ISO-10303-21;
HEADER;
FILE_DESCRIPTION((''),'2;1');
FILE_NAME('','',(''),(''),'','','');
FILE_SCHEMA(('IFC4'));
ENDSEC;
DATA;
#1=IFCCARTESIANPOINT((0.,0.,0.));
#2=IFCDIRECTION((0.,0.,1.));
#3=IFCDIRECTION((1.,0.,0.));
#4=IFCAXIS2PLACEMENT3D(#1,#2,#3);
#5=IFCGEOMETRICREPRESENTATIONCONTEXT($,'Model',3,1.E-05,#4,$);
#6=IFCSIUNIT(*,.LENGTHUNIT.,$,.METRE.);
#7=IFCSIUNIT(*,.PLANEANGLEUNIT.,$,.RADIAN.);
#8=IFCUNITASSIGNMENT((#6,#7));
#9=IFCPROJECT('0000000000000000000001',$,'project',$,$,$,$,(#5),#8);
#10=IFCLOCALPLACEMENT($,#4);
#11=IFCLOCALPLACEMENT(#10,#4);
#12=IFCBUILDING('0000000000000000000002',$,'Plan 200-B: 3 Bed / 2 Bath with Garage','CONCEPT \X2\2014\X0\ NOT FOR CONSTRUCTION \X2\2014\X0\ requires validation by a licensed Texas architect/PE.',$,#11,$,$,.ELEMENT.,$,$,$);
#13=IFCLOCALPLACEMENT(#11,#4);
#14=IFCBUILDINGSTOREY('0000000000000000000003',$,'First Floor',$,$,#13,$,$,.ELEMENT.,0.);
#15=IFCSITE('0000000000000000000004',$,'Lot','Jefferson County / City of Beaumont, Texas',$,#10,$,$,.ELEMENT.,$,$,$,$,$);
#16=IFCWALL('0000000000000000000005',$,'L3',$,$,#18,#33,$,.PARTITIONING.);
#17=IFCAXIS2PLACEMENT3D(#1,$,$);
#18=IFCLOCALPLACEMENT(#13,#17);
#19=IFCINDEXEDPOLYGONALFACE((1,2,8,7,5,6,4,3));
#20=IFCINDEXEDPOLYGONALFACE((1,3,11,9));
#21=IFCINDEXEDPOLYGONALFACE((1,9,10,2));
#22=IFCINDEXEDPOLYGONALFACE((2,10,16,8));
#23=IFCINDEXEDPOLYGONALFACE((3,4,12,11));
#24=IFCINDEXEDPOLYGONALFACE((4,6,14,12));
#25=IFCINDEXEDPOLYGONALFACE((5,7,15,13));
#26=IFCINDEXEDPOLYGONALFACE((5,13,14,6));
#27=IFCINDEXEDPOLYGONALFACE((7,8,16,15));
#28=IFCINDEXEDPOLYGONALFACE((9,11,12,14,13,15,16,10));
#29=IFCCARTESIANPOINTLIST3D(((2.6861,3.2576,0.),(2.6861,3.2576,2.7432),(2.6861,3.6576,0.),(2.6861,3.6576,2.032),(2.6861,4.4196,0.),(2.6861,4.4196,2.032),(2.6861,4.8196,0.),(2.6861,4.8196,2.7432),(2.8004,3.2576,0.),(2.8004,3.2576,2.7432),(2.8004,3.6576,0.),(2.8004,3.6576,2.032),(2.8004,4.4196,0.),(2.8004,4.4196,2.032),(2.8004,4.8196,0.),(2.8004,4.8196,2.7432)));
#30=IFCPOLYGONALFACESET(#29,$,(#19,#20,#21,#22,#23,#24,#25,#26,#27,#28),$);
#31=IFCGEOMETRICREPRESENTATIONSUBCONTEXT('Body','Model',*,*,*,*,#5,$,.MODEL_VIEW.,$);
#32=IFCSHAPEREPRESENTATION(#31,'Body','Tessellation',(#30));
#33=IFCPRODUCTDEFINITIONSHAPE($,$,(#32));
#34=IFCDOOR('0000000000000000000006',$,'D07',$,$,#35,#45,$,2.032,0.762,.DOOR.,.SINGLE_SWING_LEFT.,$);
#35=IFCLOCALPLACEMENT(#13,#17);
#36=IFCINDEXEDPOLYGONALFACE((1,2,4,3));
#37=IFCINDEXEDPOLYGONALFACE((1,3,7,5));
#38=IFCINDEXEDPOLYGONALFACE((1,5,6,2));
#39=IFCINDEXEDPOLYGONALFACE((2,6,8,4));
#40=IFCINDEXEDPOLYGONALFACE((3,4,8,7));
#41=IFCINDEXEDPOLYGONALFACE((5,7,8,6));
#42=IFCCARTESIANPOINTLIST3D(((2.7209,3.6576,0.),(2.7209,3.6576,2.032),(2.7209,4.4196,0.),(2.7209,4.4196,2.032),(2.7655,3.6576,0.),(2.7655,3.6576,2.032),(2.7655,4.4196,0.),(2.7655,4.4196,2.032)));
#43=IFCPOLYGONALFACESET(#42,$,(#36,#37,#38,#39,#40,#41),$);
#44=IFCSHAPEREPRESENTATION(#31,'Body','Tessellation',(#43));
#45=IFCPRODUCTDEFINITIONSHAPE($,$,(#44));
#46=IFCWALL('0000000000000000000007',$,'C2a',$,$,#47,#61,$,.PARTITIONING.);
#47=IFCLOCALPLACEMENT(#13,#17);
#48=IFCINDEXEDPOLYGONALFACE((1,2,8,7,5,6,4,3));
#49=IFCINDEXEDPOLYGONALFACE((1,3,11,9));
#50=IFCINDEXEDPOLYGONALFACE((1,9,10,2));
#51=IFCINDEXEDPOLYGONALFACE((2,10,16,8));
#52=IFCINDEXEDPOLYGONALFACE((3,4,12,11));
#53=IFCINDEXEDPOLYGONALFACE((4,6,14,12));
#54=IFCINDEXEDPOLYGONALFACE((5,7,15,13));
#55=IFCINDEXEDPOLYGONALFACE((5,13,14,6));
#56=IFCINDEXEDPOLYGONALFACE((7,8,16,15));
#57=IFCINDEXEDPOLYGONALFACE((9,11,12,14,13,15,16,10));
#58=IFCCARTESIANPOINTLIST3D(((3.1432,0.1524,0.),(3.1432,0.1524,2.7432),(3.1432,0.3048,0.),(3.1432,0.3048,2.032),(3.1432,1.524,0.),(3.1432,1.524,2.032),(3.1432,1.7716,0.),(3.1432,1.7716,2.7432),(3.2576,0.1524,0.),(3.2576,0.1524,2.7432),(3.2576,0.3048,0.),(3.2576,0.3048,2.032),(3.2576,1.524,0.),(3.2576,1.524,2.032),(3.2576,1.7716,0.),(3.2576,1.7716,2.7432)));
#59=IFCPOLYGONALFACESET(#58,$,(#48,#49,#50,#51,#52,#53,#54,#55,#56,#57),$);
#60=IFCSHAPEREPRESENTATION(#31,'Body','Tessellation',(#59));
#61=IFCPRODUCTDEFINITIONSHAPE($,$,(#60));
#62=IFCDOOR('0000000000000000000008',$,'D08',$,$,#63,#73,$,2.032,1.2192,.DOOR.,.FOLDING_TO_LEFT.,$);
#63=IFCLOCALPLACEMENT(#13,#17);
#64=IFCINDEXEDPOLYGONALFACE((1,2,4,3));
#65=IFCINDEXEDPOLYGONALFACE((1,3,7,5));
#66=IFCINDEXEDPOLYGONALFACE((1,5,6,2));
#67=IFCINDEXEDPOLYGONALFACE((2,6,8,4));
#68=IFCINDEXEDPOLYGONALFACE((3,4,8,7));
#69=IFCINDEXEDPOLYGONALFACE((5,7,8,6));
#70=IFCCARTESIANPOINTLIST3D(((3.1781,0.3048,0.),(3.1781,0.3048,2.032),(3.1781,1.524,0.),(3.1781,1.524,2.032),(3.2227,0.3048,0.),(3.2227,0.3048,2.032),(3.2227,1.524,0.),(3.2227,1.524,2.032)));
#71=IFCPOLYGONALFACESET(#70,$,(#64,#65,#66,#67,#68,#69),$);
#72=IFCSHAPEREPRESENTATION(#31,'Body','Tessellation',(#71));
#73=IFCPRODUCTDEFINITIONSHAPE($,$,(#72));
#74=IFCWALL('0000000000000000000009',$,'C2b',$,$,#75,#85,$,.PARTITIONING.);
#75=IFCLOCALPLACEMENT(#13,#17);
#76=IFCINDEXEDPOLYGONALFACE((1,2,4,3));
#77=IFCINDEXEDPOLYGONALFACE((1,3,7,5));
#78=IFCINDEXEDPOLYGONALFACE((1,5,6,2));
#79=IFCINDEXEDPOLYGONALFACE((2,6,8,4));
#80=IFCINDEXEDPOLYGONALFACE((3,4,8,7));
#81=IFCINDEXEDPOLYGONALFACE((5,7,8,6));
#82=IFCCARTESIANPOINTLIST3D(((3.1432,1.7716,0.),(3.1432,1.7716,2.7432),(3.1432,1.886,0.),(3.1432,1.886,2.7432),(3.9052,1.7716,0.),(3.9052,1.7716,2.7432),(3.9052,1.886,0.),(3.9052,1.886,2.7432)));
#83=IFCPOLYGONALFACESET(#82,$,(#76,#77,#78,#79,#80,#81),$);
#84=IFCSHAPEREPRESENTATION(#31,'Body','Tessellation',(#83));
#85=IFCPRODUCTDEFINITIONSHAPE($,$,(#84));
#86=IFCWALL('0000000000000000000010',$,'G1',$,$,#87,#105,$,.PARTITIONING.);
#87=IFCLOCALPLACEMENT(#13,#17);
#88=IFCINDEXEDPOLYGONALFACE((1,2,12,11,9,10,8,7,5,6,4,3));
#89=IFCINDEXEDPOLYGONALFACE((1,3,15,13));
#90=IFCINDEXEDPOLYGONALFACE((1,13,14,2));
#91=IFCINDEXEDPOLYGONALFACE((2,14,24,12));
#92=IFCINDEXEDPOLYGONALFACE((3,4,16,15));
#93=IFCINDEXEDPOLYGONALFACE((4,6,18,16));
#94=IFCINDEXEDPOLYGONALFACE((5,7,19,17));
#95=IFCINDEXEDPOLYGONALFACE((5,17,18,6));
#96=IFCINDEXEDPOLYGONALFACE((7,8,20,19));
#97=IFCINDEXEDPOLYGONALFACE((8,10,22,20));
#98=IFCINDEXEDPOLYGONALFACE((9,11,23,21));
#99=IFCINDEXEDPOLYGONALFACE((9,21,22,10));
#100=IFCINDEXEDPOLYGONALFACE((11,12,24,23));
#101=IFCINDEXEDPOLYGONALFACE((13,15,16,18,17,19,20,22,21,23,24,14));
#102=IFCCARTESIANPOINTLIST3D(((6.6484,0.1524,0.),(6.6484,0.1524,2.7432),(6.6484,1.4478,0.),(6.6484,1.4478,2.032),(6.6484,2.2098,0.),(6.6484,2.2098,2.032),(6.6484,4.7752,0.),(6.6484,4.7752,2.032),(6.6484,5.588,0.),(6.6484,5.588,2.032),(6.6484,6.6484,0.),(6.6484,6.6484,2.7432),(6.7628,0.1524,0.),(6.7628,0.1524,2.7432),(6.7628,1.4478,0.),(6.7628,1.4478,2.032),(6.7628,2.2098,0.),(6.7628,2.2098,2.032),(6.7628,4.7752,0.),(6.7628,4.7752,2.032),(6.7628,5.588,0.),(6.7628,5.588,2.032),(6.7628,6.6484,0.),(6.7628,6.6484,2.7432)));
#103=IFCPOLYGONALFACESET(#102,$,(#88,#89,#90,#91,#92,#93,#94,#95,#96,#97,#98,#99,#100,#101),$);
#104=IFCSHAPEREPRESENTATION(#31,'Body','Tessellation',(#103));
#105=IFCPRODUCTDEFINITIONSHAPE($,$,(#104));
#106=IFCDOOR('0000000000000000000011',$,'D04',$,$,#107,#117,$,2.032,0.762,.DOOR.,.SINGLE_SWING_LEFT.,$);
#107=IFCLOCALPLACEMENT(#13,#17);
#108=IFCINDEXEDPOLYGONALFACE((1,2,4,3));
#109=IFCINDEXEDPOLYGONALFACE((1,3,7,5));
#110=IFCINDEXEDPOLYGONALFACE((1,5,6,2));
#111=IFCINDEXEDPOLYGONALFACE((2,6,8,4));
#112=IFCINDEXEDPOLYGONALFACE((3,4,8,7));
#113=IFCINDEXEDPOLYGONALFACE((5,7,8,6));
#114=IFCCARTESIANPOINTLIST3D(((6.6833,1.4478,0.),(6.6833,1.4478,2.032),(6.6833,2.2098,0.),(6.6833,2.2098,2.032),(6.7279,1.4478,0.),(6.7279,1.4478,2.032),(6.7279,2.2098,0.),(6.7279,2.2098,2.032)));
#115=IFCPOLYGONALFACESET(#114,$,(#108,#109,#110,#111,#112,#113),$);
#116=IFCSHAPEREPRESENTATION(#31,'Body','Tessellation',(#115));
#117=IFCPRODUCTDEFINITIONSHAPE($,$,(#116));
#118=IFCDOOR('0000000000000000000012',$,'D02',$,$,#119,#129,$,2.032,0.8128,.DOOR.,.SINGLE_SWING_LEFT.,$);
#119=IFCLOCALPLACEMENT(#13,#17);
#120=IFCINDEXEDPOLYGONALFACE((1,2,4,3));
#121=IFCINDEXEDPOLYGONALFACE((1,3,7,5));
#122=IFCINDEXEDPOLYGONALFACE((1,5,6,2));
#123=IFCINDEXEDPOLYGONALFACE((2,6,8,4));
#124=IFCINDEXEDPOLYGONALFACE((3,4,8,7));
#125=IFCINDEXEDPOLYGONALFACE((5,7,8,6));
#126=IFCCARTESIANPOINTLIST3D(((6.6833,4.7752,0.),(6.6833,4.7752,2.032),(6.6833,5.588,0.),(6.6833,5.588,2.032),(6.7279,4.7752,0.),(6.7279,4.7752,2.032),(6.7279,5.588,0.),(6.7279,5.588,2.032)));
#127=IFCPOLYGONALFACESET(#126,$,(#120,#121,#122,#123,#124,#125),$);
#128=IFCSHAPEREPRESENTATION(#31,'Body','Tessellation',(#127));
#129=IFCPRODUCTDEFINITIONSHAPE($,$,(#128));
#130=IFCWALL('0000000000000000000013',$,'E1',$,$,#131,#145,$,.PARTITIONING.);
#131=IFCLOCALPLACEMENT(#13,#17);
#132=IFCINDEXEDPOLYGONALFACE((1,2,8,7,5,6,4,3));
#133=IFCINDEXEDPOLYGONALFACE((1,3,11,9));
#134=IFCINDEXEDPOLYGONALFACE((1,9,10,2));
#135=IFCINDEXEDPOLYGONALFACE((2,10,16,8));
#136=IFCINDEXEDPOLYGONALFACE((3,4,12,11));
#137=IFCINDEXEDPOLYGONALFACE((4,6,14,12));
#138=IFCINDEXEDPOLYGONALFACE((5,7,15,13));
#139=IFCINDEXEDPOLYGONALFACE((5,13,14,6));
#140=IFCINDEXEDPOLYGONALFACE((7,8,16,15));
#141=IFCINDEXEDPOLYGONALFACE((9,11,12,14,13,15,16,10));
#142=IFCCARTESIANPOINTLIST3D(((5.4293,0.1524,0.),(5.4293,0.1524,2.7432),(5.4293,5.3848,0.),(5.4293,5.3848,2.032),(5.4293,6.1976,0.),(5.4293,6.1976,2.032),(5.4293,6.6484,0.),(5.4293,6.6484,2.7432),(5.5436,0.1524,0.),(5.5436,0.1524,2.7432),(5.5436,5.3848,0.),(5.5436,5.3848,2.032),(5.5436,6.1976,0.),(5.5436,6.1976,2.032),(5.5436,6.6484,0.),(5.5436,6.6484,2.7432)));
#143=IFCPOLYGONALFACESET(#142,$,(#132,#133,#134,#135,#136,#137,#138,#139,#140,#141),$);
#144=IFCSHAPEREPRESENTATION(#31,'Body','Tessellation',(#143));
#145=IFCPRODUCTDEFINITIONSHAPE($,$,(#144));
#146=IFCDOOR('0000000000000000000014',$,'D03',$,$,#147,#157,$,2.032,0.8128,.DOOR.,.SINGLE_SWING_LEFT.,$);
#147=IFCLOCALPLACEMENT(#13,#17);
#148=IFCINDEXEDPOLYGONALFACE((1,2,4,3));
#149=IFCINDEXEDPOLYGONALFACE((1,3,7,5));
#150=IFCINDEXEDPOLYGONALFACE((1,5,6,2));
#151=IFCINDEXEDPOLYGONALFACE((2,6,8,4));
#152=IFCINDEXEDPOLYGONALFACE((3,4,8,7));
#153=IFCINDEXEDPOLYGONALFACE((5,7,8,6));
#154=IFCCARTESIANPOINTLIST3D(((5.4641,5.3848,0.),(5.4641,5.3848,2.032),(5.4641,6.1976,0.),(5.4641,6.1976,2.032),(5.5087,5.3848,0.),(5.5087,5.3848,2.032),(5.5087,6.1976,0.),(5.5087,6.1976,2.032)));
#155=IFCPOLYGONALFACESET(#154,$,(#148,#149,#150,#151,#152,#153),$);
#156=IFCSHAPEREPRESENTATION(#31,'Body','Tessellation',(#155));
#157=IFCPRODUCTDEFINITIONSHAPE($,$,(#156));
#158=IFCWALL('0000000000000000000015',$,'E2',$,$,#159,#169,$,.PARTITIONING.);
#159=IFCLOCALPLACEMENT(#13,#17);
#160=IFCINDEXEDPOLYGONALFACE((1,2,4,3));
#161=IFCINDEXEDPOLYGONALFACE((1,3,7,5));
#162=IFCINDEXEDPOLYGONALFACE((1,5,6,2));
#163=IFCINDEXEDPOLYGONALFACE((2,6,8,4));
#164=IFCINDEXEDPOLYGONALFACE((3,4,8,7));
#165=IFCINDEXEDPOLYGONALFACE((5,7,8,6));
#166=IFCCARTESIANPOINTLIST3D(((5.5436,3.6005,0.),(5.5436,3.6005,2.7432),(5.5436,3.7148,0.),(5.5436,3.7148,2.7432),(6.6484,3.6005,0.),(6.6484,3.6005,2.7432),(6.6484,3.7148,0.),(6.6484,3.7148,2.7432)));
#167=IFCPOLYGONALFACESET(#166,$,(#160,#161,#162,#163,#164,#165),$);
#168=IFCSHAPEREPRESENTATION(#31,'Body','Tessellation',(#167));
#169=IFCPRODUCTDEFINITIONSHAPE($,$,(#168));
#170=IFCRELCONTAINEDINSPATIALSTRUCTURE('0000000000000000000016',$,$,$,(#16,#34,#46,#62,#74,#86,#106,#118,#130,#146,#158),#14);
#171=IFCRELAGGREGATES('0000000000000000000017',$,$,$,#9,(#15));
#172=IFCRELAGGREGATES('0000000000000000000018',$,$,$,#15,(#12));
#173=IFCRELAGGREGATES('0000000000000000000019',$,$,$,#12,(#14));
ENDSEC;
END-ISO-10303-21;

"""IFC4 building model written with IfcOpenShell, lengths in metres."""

from ifc_helpers import new_model, si_unit, frame, frame_2d, origin_with_axes, place, context, subcontext, project, spatial, rectangle, extrude, element, fill, save


model = new_model("IFC4")

# Units and contexts
model_context = context("Model", 3, precision=1e-05, world=origin_with_axes())
body_context = subcontext(model_context, "Body", "Model", "MODEL_VIEW")
ifc_project = project(units=[si_unit("LENGTHUNIT", "METRE"), si_unit("PLANEANGLEUNIT", "RADIAN")], contexts=[model_context])

# Site, building, storey
site_placement = place(None, origin_with_axes())
site = spatial("IfcSite", under=ifc_project, at=site_placement, Name="Lot", Description="Jefferson County / City of Beaumont, Texas", CompositionType="ELEMENT")
building_placement = place(site_placement, origin_with_axes())
building = spatial("IfcBuilding", under=site, at=building_placement, Name="Plan 200-B: 3 Bed / 2 Bath with Garage", Description="CONCEPT — NOT FOR CONSTRUCTION — requires validation by a licensed Texas architect/PE.", CompositionType="ELEMENT")
storey_placement = place(building_placement, origin_with_axes())
storey = spatial("IfcBuildingStorey", under=building, at=storey_placement, Name="First Floor", CompositionType="ELEMENT", Elevation=0.0)

# Walls, openings, doors
wall_1_placement = place(storey_placement, frame((2.7432, 3.2576, 0.0), z_axis=(0.0, 0.0, 1.0), x_axis=(0.0, 1.0, 0.0)))
wall_1 = element("IfcWall", 1, at=wall_1_placement, inside=storey, Name="L3", PredefinedType="PARTITIONING", context=body_context, shape_type="SweptSolid", body=[
    extrude(rectangle(XDim=1.5621, YDim=0.1143, at=frame_2d((0.7811, 0.0), x_axis=(1.0, 0.0))), origin_with_axes(), (0.0, 0.0, 1.0), 2.7432),
])
opening_1_placement = place(wall_1_placement, frame((0.4001, 0.0, 0.0), z_axis=(0.0, 0.0, 1.0), x_axis=(1.0, 0.0, 0.0)))
opening_1 = element("IfcOpeningElement", 2, at=opening_1_placement, cuts=wall_1, PredefinedType="OPENING", context=body_context, shape_type="SweptSolid", body=[
    extrude(rectangle(XDim=0.762, YDim=0.1448, at=frame_2d((0.381, 0.0), x_axis=(1.0, 0.0))), origin_with_axes(), (0.0, 0.0, 1.0), 2.032),
])
door_1_placement = place(opening_1_placement, origin_with_axes())
door_1 = element("IfcDoor", 3, at=door_1_placement, inside=storey, Name="D07", OperationType="SINGLE_SWING_LEFT", OverallHeight=2.032, OverallWidth=0.762, PredefinedType="DOOR", context=body_context, shape_type="SweptSolid", body=[
    extrude(rectangle(XDim=0.762, YDim=0.0445, at=frame_2d((0.381, 0.0), x_axis=(1.0, 0.0))), origin_with_axes(), (0.0, 0.0, 1.0), 2.032),
])
fill(opening_1, door_1)
wall_2_placement = place(storey_placement, frame((3.2004, 0.1524, 0.0), z_axis=(0.0, 0.0, 1.0), x_axis=(0.0, 1.0, 0.0)))
wall_2 = element("IfcWall", 4, at=wall_2_placement, inside=storey, Name="C2a", PredefinedType="PARTITIONING", context=body_context, shape_type="SweptSolid", body=[
    extrude(rectangle(XDim=1.6193, YDim=0.1143, at=frame_2d((0.8096, 0.0), x_axis=(1.0, 0.0))), origin_with_axes(), (0.0, 0.0, 1.0), 2.7432),
])
opening_2_placement = place(wall_2_placement, frame((0.1524, 0.0, 0.0), z_axis=(0.0, 0.0, 1.0), x_axis=(1.0, 0.0, 0.0)))
opening_2 = element("IfcOpeningElement", 5, at=opening_2_placement, cuts=wall_2, PredefinedType="OPENING", context=body_context, shape_type="SweptSolid", body=[
    extrude(rectangle(XDim=1.2192, YDim=0.1448, at=frame_2d((0.6096, 0.0), x_axis=(1.0, 0.0))), origin_with_axes(), (0.0, 0.0, 1.0), 2.032),
])
door_2_placement = place(opening_2_placement, origin_with_axes())
door_2 = element("IfcDoor", 6, at=door_2_placement, inside=storey, Name="D08", OperationType="FOLDING_TO_LEFT", OverallHeight=2.032, OverallWidth=1.2192, PredefinedType="DOOR", context=body_context, shape_type="SweptSolid", body=[
    extrude(rectangle(XDim=1.2192, YDim=0.0445, at=frame_2d((0.6096, 0.0), x_axis=(1.0, 0.0))), origin_with_axes(), (0.0, 0.0, 1.0), 2.032),
])
fill(opening_2, door_2)

# Wall
wall_3_placement = place(storey_placement, frame((3.1433, 1.8288, 0.0), z_axis=(0.0, 0.0, 1.0), x_axis=(1.0, 0.0, 0.0)))
element("IfcWall", 7, at=wall_3_placement, inside=storey, Name="C2b", PredefinedType="PARTITIONING", context=body_context, shape_type="SweptSolid", body=[
    extrude(rectangle(XDim=0.762, YDim=0.1143, at=frame_2d((0.381, 0.0), x_axis=(1.0, 0.0))), origin_with_axes(), (0.0, 0.0, 1.0), 2.7432),
])

# Wall, openings, doors
wall_4_placement = place(storey_placement, frame((6.7056, 0.1524, 0.0), z_axis=(0.0, 0.0, 1.0), x_axis=(0.0, 1.0, 0.0)))
wall_4 = element("IfcWall", 8, at=wall_4_placement, inside=storey, Name="G1", PredefinedType="PARTITIONING", context=body_context, shape_type="SweptSolid", body=[
    extrude(rectangle(XDim=6.4961, YDim=0.1143, at=frame_2d((3.248, 0.0), x_axis=(1.0, 0.0))), origin_with_axes(), (0.0, 0.0, 1.0), 2.7432),
])
opening_3_placement = place(wall_4_placement, frame((1.2954, 0.0, 0.0), z_axis=(0.0, 0.0, 1.0), x_axis=(1.0, 0.0, 0.0)))
opening_3 = element("IfcOpeningElement", 9, at=opening_3_placement, cuts=wall_4, PredefinedType="OPENING", context=body_context, shape_type="SweptSolid", body=[
    extrude(rectangle(XDim=0.762, YDim=0.1448, at=frame_2d((0.381, 0.0), x_axis=(1.0, 0.0))), origin_with_axes(), (0.0, 0.0, 1.0), 2.032),
])
opening_4_placement = place(wall_4_placement, frame((4.6228, 0.0, 0.0), z_axis=(0.0, 0.0, 1.0), x_axis=(1.0, 0.0, 0.0)))
opening_4 = element("IfcOpeningElement", 10, at=opening_4_placement, cuts=wall_4, PredefinedType="OPENING", context=body_context, shape_type="SweptSolid", body=[
    extrude(rectangle(XDim=0.8128, YDim=0.1448, at=frame_2d((0.4064, 0.0), x_axis=(1.0, 0.0))), origin_with_axes(), (0.0, 0.0, 1.0), 2.032),
])
door_3_placement = place(opening_3_placement, origin_with_axes())
door_3 = element("IfcDoor", 11, at=door_3_placement, inside=storey, Name="D04", OperationType="SINGLE_SWING_LEFT", OverallHeight=2.032, OverallWidth=0.762, PredefinedType="DOOR", context=body_context, shape_type="SweptSolid", body=[
    extrude(rectangle(XDim=0.762, YDim=0.0445, at=frame_2d((0.381, 0.0), x_axis=(1.0, 0.0))), origin_with_axes(), (0.0, 0.0, 1.0), 2.032),
])
fill(opening_3, door_3)
door_4_placement = place(opening_4_placement, origin_with_axes())
door_4 = element("IfcDoor", 12, at=door_4_placement, inside=storey, Name="D02", OperationType="SINGLE_SWING_LEFT", OverallHeight=2.032, OverallWidth=0.8128, PredefinedType="DOOR", context=body_context, shape_type="SweptSolid", body=[
    extrude(rectangle(XDim=0.8128, YDim=0.0445, at=frame_2d((0.4064, 0.0), x_axis=(1.0, 0.0))), origin_with_axes(), (0.0, 0.0, 1.0), 2.032),
])
fill(opening_4, door_4)

# Wall, opening, door
wall_5_placement = place(storey_placement, frame((5.4864, 0.1524, 0.0), z_axis=(0.0, 0.0, 1.0), x_axis=(0.0, 1.0, 0.0)))
wall_5 = element("IfcWall", 13, at=wall_5_placement, inside=storey, Name="E1", PredefinedType="PARTITIONING", context=body_context, shape_type="SweptSolid", body=[
    extrude(rectangle(XDim=6.4961, YDim=0.1143, at=frame_2d((3.248, 0.0), x_axis=(1.0, 0.0))), origin_with_axes(), (0.0, 0.0, 1.0), 2.7432),
])
opening_5_placement = place(wall_5_placement, frame((5.2324, 0.0, 0.0), z_axis=(0.0, 0.0, 1.0), x_axis=(1.0, 0.0, 0.0)))
opening_5 = element("IfcOpeningElement", 14, at=opening_5_placement, cuts=wall_5, PredefinedType="OPENING", context=body_context, shape_type="SweptSolid", body=[
    extrude(rectangle(XDim=0.8128, YDim=0.1448, at=frame_2d((0.4064, 0.0), x_axis=(1.0, 0.0))), origin_with_axes(), (0.0, 0.0, 1.0), 2.032),
])
door_5_placement = place(opening_5_placement, origin_with_axes())
door_5 = element("IfcDoor", 15, at=door_5_placement, inside=storey, Name="D03", OperationType="SINGLE_SWING_LEFT", OverallHeight=2.032, OverallWidth=0.8128, PredefinedType="DOOR", context=body_context, shape_type="SweptSolid", body=[
    extrude(rectangle(XDim=0.8128, YDim=0.0445, at=frame_2d((0.4064, 0.0), x_axis=(1.0, 0.0))), origin_with_axes(), (0.0, 0.0, 1.0), 2.032),
])
fill(opening_5, door_5)

# Wall
wall_6_placement = place(storey_placement, frame((5.5436, 3.6576, 0.0), z_axis=(0.0, 0.0, 1.0), x_axis=(1.0, 0.0, 0.0)))
element("IfcWall", 16, at=wall_6_placement, inside=storey, Name="E2", PredefinedType="PARTITIONING", context=body_context, shape_type="SweptSolid", body=[
    extrude(rectangle(XDim=1.1049, YDim=0.1143, at=frame_2d((0.5524, 0.0), x_axis=(1.0, 0.0))), origin_with_axes(), (0.0, 0.0, 1.0), 2.7432),
])

save(model, "model.ifc")
